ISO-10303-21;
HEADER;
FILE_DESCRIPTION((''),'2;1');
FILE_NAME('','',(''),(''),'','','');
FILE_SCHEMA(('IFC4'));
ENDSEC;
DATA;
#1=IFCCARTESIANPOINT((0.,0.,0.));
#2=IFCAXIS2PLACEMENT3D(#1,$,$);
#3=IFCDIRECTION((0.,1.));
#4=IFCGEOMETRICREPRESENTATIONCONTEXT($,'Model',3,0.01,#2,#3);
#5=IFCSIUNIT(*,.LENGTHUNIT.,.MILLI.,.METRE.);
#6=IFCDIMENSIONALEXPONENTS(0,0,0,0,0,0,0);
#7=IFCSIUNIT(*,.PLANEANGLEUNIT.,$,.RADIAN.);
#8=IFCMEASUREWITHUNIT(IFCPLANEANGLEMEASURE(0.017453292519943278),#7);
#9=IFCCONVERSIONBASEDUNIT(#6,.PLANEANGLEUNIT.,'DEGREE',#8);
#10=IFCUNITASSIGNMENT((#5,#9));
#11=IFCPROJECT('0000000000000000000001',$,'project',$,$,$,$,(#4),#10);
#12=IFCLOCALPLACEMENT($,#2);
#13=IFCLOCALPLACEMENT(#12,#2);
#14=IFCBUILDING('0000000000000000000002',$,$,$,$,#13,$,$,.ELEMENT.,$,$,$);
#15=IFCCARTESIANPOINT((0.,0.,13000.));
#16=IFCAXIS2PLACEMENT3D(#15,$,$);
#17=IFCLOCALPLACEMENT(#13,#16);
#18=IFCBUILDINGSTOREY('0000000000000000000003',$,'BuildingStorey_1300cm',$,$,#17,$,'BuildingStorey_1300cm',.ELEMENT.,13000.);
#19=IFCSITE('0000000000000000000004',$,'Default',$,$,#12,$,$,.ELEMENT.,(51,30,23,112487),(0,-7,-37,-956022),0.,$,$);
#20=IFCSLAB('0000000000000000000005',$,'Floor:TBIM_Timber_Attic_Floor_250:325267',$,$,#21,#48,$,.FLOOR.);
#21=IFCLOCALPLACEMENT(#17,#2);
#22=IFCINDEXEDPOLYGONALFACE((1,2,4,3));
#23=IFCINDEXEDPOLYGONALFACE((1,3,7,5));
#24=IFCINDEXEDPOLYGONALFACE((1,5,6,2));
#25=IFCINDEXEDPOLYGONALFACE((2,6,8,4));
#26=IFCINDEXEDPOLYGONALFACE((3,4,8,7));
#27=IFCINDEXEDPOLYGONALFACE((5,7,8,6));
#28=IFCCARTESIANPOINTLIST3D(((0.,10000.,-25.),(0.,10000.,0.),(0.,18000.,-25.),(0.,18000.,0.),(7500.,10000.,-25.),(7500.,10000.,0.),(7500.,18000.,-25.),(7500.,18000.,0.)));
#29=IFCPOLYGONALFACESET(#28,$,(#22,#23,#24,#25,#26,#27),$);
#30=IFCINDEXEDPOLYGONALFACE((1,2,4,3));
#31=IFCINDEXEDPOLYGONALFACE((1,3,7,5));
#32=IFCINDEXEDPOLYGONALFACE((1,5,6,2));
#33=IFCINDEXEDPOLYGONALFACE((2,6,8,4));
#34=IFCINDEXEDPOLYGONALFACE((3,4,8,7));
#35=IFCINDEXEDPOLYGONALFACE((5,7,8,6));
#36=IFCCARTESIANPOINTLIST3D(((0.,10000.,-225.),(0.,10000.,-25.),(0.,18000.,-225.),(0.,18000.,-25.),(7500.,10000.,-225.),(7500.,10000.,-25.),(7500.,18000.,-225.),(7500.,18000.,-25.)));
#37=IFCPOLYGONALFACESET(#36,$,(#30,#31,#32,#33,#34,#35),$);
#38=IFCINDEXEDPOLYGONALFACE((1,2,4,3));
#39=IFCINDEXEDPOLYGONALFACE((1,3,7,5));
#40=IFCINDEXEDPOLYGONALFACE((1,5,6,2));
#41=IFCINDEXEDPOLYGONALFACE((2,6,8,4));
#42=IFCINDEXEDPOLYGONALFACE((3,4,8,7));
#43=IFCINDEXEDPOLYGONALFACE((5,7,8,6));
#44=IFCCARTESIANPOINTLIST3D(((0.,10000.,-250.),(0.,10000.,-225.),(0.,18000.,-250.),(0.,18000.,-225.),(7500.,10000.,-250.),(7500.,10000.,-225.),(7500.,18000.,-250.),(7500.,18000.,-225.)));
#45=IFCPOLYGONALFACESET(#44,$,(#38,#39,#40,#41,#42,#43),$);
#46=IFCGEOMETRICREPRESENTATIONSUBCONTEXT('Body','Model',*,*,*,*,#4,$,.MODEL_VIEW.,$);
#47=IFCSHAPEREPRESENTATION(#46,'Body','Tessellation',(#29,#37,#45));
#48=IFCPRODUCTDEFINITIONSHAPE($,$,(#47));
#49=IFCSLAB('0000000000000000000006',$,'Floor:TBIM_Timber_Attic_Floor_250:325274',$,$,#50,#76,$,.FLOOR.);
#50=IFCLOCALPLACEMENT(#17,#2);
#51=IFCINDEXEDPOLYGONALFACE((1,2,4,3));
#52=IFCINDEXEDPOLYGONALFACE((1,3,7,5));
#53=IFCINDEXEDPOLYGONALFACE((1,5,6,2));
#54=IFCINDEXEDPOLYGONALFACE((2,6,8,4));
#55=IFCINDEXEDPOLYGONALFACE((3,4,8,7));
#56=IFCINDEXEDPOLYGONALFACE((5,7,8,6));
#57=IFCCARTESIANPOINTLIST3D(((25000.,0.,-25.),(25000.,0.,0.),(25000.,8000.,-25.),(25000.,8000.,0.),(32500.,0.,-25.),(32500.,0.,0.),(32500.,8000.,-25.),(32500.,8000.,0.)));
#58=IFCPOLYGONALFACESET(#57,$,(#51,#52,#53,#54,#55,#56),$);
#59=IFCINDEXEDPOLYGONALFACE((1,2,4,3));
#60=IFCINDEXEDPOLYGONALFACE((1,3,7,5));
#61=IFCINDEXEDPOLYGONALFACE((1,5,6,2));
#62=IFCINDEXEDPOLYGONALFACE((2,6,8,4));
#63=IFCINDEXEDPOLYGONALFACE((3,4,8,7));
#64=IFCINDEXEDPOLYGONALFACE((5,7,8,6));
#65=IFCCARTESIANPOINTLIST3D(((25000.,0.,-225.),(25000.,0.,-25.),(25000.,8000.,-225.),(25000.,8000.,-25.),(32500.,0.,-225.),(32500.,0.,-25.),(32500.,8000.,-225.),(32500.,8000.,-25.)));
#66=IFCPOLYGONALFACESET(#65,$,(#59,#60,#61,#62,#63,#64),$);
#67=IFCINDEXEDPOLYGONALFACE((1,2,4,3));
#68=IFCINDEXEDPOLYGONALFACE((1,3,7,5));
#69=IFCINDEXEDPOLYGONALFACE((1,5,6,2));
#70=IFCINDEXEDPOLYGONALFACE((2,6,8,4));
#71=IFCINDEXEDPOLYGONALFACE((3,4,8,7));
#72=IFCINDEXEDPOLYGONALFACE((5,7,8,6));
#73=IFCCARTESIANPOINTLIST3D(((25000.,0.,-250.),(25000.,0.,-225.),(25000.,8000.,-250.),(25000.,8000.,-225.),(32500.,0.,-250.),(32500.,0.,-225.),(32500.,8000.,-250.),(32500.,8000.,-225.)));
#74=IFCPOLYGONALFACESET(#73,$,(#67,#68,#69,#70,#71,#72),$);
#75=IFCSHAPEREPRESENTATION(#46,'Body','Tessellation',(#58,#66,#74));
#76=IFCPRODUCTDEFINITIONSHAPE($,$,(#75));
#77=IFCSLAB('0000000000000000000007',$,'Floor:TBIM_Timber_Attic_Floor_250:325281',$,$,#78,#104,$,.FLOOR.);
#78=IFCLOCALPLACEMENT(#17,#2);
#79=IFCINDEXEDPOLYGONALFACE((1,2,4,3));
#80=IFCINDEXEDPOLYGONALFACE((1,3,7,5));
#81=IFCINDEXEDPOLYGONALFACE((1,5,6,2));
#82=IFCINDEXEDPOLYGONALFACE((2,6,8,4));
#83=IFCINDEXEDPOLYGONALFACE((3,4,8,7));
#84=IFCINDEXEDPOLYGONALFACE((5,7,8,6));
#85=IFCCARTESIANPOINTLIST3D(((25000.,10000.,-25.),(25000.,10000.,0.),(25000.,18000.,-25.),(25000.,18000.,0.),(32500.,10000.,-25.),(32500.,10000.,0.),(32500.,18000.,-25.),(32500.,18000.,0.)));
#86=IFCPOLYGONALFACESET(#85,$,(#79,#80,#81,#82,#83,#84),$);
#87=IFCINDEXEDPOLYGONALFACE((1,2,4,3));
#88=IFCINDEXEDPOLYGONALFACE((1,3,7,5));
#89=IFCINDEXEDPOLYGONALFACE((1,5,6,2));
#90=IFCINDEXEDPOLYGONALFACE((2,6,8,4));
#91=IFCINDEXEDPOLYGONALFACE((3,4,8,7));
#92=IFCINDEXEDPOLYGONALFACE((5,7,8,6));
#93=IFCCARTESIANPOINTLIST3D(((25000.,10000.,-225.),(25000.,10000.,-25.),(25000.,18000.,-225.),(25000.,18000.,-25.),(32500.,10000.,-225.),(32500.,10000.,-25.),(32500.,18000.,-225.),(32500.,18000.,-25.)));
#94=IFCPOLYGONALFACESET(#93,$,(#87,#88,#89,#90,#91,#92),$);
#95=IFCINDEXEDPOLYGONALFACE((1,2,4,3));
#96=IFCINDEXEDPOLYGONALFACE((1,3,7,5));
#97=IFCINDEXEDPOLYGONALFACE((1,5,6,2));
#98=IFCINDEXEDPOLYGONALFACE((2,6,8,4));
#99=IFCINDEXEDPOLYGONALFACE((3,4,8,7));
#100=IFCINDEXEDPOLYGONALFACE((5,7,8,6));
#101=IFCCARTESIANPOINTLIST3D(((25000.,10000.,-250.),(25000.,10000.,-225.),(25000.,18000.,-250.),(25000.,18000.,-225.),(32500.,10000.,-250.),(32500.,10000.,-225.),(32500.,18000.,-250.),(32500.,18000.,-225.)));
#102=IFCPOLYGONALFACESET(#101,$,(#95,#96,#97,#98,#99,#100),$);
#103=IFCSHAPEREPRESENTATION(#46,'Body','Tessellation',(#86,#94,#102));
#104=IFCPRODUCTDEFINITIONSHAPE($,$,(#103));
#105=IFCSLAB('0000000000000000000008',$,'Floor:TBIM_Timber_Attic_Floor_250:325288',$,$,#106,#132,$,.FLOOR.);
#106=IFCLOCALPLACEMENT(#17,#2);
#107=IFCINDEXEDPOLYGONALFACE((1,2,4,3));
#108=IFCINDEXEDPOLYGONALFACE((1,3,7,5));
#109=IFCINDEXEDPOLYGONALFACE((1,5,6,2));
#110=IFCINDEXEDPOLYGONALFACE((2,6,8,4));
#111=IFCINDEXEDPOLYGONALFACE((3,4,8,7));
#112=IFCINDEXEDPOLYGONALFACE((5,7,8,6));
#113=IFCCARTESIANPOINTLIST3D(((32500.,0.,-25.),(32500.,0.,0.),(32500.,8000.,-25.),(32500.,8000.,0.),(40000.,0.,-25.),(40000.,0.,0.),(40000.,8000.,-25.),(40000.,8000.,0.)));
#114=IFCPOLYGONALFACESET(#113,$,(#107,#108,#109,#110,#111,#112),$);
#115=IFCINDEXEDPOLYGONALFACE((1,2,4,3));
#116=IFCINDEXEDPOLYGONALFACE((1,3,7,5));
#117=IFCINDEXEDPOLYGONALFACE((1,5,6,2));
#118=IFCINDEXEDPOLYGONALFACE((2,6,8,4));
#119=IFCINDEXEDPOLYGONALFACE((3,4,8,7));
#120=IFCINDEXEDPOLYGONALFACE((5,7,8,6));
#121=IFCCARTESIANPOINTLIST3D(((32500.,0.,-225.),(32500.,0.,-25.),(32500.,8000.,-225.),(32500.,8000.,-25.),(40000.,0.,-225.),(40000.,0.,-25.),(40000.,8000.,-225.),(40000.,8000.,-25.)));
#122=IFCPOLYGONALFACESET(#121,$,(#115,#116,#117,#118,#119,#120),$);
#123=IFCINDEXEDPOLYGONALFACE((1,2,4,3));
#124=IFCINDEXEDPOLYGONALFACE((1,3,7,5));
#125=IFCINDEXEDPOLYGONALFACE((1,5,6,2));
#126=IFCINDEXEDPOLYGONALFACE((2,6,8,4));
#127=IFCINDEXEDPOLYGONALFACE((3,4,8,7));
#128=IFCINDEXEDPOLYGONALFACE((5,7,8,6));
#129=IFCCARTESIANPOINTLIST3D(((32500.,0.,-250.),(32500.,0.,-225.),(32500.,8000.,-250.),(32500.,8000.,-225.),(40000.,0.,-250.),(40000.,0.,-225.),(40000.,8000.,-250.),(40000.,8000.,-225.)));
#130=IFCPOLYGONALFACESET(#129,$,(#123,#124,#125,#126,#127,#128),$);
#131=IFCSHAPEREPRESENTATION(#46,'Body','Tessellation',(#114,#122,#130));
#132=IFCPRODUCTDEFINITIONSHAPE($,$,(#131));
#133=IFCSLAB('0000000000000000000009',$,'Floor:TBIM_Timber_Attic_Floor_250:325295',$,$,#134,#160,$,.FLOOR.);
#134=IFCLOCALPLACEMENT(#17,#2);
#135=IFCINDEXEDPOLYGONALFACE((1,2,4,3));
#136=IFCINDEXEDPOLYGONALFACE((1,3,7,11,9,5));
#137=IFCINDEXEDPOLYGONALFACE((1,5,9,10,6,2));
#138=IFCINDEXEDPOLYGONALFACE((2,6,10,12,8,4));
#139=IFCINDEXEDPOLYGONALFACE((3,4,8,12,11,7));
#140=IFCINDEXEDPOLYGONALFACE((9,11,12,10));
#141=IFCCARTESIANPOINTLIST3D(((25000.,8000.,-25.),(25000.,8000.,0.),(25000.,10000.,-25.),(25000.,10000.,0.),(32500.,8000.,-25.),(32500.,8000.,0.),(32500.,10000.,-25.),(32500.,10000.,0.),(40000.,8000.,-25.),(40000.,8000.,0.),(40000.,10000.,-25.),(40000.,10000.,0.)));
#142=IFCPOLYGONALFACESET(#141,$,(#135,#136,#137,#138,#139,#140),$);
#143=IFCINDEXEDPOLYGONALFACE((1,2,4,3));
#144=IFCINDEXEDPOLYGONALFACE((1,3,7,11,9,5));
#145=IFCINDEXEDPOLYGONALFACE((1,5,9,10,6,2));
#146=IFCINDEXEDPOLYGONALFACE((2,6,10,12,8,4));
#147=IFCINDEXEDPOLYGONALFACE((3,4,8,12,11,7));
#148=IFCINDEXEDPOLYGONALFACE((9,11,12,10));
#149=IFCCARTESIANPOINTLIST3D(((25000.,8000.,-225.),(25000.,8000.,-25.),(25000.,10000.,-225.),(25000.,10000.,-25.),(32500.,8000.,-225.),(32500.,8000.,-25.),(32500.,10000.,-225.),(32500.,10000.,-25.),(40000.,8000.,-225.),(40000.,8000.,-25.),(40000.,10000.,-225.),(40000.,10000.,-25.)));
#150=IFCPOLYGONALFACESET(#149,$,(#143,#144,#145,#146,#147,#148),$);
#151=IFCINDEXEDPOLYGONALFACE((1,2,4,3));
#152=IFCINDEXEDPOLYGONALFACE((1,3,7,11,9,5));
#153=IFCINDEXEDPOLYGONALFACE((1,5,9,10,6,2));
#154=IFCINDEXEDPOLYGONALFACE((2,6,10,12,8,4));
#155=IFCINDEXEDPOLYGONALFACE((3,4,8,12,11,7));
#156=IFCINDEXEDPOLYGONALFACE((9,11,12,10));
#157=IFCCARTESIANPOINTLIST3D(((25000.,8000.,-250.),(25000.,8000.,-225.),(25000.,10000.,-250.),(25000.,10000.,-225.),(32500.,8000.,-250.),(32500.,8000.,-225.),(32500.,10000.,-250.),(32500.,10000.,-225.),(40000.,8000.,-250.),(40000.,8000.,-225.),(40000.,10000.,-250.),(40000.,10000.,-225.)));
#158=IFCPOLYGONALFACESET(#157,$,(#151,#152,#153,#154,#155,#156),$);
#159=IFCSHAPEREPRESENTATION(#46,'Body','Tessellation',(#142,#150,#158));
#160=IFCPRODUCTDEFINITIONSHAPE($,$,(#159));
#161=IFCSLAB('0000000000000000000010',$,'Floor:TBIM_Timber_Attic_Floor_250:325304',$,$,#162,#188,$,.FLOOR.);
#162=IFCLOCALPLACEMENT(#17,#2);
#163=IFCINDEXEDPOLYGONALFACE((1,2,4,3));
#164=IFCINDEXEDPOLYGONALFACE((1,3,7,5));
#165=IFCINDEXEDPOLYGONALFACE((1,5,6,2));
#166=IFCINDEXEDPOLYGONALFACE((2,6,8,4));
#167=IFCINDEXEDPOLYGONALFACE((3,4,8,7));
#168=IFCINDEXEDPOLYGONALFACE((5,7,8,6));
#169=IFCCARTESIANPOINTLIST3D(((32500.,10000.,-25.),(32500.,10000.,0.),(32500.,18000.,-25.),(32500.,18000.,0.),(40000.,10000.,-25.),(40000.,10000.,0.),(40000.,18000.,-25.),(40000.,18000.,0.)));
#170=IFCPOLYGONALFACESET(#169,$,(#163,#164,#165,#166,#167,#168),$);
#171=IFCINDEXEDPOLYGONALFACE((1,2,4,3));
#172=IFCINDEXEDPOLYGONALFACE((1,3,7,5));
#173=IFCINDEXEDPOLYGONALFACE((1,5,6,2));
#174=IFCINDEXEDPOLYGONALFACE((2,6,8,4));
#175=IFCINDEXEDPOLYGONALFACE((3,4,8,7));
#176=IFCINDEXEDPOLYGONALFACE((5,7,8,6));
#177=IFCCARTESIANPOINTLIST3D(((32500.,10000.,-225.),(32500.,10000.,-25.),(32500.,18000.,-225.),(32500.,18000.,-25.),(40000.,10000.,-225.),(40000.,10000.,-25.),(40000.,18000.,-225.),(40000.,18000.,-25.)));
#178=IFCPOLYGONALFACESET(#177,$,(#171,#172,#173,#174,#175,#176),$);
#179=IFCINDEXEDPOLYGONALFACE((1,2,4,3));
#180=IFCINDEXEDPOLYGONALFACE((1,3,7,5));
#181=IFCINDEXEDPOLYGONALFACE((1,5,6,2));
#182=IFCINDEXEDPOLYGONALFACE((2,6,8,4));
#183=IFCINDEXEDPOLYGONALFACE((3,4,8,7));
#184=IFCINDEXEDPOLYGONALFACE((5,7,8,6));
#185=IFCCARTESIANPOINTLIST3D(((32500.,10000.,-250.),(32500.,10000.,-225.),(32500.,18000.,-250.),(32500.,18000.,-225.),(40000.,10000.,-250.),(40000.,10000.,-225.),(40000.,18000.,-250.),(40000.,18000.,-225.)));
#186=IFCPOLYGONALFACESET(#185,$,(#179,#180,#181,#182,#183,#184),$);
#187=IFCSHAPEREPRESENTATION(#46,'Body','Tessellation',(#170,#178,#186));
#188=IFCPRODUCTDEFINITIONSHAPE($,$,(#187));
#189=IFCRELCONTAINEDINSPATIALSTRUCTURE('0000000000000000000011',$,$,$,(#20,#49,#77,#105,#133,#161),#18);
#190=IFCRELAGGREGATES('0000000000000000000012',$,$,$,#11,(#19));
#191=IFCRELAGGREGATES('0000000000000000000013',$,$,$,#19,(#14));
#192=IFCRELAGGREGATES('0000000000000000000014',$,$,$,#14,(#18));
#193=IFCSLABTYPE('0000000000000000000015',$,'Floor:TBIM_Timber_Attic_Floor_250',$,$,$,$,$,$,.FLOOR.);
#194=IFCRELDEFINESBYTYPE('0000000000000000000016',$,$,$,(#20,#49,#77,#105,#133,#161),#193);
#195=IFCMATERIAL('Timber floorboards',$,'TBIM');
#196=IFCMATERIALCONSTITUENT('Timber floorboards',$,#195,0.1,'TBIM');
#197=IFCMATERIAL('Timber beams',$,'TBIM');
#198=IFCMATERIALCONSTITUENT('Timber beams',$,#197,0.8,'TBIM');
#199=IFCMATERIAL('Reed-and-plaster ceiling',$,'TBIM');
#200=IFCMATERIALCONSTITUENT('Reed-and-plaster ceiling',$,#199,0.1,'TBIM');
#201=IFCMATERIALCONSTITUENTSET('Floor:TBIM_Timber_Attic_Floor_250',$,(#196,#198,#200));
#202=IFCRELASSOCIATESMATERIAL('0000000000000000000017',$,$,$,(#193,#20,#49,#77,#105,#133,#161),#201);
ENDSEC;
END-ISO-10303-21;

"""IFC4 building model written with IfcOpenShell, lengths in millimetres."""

from ifc_helpers import new_model, entity, si_unit, converted_unit, direction, frame, origin, place, context, subcontext, project, spatial, indexed_curve, outline, extrude, material, constituent, constituent_set, type_object, element, save


model = new_model("IFC4")

# Units and contexts
model_context = context("Model", 3, precision=0.01, world=origin(), true_north=direction((0.0, 1.0)))
body_context = subcontext(model_context, "Body", "Model", "MODEL_VIEW")
ifc_project = project(units=[si_unit("LENGTHUNIT", "METRE", prefix="MILLI"), converted_unit("PLANEANGLEUNIT", "DEGREE", entity("IfcPlaneAngleMeasure", 0.017453292519943278), si_unit("PLANEANGLEUNIT", "RADIAN"), dimensions=[0, 0, 0, 0, 0, 0, 0])], contexts=[model_context])

# Site, building, storey
site_placement = place(None, origin())
site = spatial("IfcSite", under=ifc_project, at=site_placement, Name="Default", CompositionType="ELEMENT", RefLatitude=(51, 30, 23, 112487), RefLongitude=(0, -7, -37, -956022), RefElevation=0.0)
building_placement = place(site_placement, origin())
building = spatial("IfcBuilding", under=site, at=building_placement, CompositionType="ELEMENT")
storey_placement = place(building_placement, frame((0.0, 0.0, 13000.0)))
storey = spatial("IfcBuildingStorey", under=building, at=storey_placement, Name="BuildingStorey_1300cm", LongName="BuildingStorey_1300cm", CompositionType="ELEMENT", Elevation=13000.0)

# Slabs
ifc_material_1 = material(Name="Timber floorboards", Category="TBIM")
ifc_constituent_1 = constituent(ifc_material_1, Name="Timber floorboards", Category="TBIM", fraction=0.1)
ifc_material_2 = material(Name="Timber beams", Category="TBIM")
ifc_constituent_2 = constituent(ifc_material_2, Name="Timber beams", Category="TBIM", fraction=0.8)
ifc_material_3 = material(Name="Reed-and-plaster ceiling", Category="TBIM")
ifc_constituent_3 = constituent(ifc_material_3, Name="Reed-and-plaster ceiling", Category="TBIM", fraction=0.1)
ifc_constituent_set_1 = constituent_set(constituents=[ifc_constituent_1, ifc_constituent_2, ifc_constituent_3], Name="Floor:TBIM_Timber_Attic_Floor_250")
slab_type_1 = type_object("IfcSlabType", Name="Floor:TBIM_Timber_Attic_Floor_250", PredefinedType="FLOOR", material=ifc_constituent_set_1)
slab_1_placement = place(storey_placement, origin())
element("IfcSlab", 1, at=slab_1_placement, inside=storey, type_object=slab_type_1, material=ifc_constituent_set_1, Name="Floor:TBIM_Timber_Attic_Floor_250:325267", PredefinedType="FLOOR", context=body_context, shape_type="SweptSolid", body=[
    extrude(outline(indexed_curve([(-3750.0, -4000.0), (3750.0, -4000.0), (3750.0, 4000.0), (-3750.0, 4000.0), (-3750.0, -4000.0)], self_intersect=False)), frame((3750.0, 14000.0, -25.0), z_axis=(0.0, 0.0, 1.0), x_axis=(-1.0, 0.0, 0.0)), (0.0, 0.0, 1.0), 25.0),
    extrude(outline(indexed_curve([(-3750.0, -4000.0), (3750.0, -4000.0), (3750.0, 4000.0), (-3750.0, 4000.0), (-3750.0, -4000.0)], self_intersect=False)), frame((3750.0, 14000.0, -225.0), z_axis=(0.0, 0.0, 1.0), x_axis=(-1.0, 0.0, 0.0)), (0.0, 0.0, 1.0), 200.0),
    extrude(outline(indexed_curve([(-3750.0, -4000.0), (3750.0, -4000.0), (3750.0, 4000.0), (-3750.0, 4000.0), (-3750.0, -4000.0)], self_intersect=False)), frame((3750.0, 14000.0, -250.0), z_axis=(0.0, 0.0, 1.0), x_axis=(-1.0, 0.0, 0.0)), (0.0, 0.0, 1.0), 25.0),
])
slab_2_placement = place(storey_placement, origin())
element("IfcSlab", 2, at=slab_2_placement, inside=storey, type_object=slab_type_1, material=ifc_constituent_set_1, Name="Floor:TBIM_Timber_Attic_Floor_250:325274", PredefinedType="FLOOR", context=body_context, shape_type="SweptSolid", body=[
    extrude(outline(indexed_curve([(-3750.0, -4000.0), (3750.0, -4000.0), (3750.0, 4000.0), (-3750.0, 4000.0), (-3750.0, -4000.0)], self_intersect=False)), frame((28750.0, 4000.0, -25.0), z_axis=(0.0, 0.0, 1.0), x_axis=(-1.0, 0.0, 0.0)), (0.0, 0.0, 1.0), 25.0),
    extrude(outline(indexed_curve([(-3750.0, -4000.0), (3750.0, -4000.0), (3750.0, 4000.0), (-3750.0, 4000.0), (-3750.0, -4000.0)], self_intersect=False)), frame((28750.0, 4000.0, -225.0), z_axis=(0.0, 0.0, 1.0), x_axis=(-1.0, 0.0, 0.0)), (0.0, 0.0, 1.0), 200.0),
    extrude(outline(indexed_curve([(-3750.0, -4000.0), (3750.0, -4000.0), (3750.0, 4000.0), (-3750.0, 4000.0), (-3750.0, -4000.0)], self_intersect=False)), frame((28750.0, 4000.0, -250.0), z_axis=(0.0, 0.0, 1.0), x_axis=(-1.0, 0.0, 0.0)), (0.0, 0.0, 1.0), 25.0),
])
slab_3_placement = place(storey_placement, origin())
element("IfcSlab", 3, at=slab_3_placement, inside=storey, type_object=slab_type_1, material=ifc_constituent_set_1, Name="Floor:TBIM_Timber_Attic_Floor_250:325281", PredefinedType="FLOOR", context=body_context, shape_type="SweptSolid", body=[
    extrude(outline(indexed_curve([(-3750.0, -4000.0), (3750.0, -4000.0), (3750.0, 4000.0), (-3750.0, 4000.0), (-3750.0, -4000.0)], self_intersect=False)), frame((28750.0, 14000.0, -25.0), z_axis=(0.0, 0.0, 1.0), x_axis=(-1.0, 0.0, 0.0)), (0.0, 0.0, 1.0), 25.0),
    extrude(outline(indexed_curve([(-3750.0, -4000.0), (3750.0, -4000.0), (3750.0, 4000.0), (-3750.0, 4000.0), (-3750.0, -4000.0)], self_intersect=False)), frame((28750.0, 14000.0, -225.0), z_axis=(0.0, 0.0, 1.0), x_axis=(-1.0, 0.0, 0.0)), (0.0, 0.0, 1.0), 200.0),
    extrude(outline(indexed_curve([(-3750.0, -4000.0), (3750.0, -4000.0), (3750.0, 4000.0), (-3750.0, 4000.0), (-3750.0, -4000.0)], self_intersect=False)), frame((28750.0, 14000.0, -250.0), z_axis=(0.0, 0.0, 1.0), x_axis=(-1.0, 0.0, 0.0)), (0.0, 0.0, 1.0), 25.0),
])
slab_4_placement = place(storey_placement, origin())
element("IfcSlab", 4, at=slab_4_placement, inside=storey, type_object=slab_type_1, material=ifc_constituent_set_1, Name="Floor:TBIM_Timber_Attic_Floor_250:325288", PredefinedType="FLOOR", context=body_context, shape_type="SweptSolid", body=[
    extrude(outline(indexed_curve([(-3750.0, -4000.0), (3750.0, -4000.0), (3750.0, 4000.0), (-3750.0, 4000.0), (-3750.0, -4000.0)], self_intersect=False)), frame((36250.0, 4000.0, -25.0), z_axis=(0.0, 0.0, 1.0), x_axis=(-1.0, 0.0, 0.0)), (0.0, 0.0, 1.0), 25.0),
    extrude(outline(indexed_curve([(-3750.0, -4000.0), (3750.0, -4000.0), (3750.0, 4000.0), (-3750.0, 4000.0), (-3750.0, -4000.0)], self_intersect=False)), frame((36250.0, 4000.0, -225.0), z_axis=(0.0, 0.0, 1.0), x_axis=(-1.0, 0.0, 0.0)), (0.0, 0.0, 1.0), 200.0),
    extrude(outline(indexed_curve([(-3750.0, -4000.0), (3750.0, -4000.0), (3750.0, 4000.0), (-3750.0, 4000.0), (-3750.0, -4000.0)], self_intersect=False)), frame((36250.0, 4000.0, -250.0), z_axis=(0.0, 0.0, 1.0), x_axis=(-1.0, 0.0, 0.0)), (0.0, 0.0, 1.0), 25.0),
])
slab_5_placement = place(storey_placement, origin())
element("IfcSlab", 5, at=slab_5_placement, inside=storey, type_object=slab_type_1, material=ifc_constituent_set_1, Name="Floor:TBIM_Timber_Attic_Floor_250:325295", PredefinedType="FLOOR", context=body_context, shape_type="SweptSolid", body=[
    extrude(outline(indexed_curve([(-7500.0, -1000.0), (0.0, -1000.0), (7500.0, -1000.0), (7500.0, 1000.0), (0.0, 1000.0), (-7500.0, 1000.0), (-7500.0, -1000.0)], self_intersect=False)), frame((32500.0, 9000.0, -25.0), z_axis=(0.0, 0.0, 1.0), x_axis=(-1.0, 0.0, 0.0)), (0.0, 0.0, 1.0), 25.0),
    extrude(outline(indexed_curve([(-7500.0, -1000.0), (0.0, -1000.0), (7500.0, -1000.0), (7500.0, 1000.0), (0.0, 1000.0), (-7500.0, 1000.0), (-7500.0, -1000.0)], self_intersect=False)), frame((32500.0, 9000.0, -225.0), z_axis=(0.0, 0.0, 1.0), x_axis=(-1.0, 0.0, 0.0)), (0.0, 0.0, 1.0), 200.0),
    extrude(outline(indexed_curve([(-7500.0, -1000.0), (0.0, -1000.0), (7500.0, -1000.0), (7500.0, 1000.0), (0.0, 1000.0), (-7500.0, 1000.0), (-7500.0, -1000.0)], self_intersect=False)), frame((32500.0, 9000.0, -250.0), z_axis=(0.0, 0.0, 1.0), x_axis=(-1.0, 0.0, 0.0)), (0.0, 0.0, 1.0), 25.0),
])
slab_6_placement = place(storey_placement, origin())
element("IfcSlab", 6, at=slab_6_placement, inside=storey, type_object=slab_type_1, material=ifc_constituent_set_1, Name="Floor:TBIM_Timber_Attic_Floor_250:325304", PredefinedType="FLOOR", context=body_context, shape_type="SweptSolid", body=[
    extrude(outline(indexed_curve([(-3750.0, -4000.0), (3750.0, -4000.0), (3750.0, 4000.0), (-3750.0, 4000.0), (-3750.0, -4000.0)], self_intersect=False)), frame((36250.0, 14000.0, -25.0), z_axis=(0.0, 0.0, 1.0), x_axis=(-1.0, 0.0, 0.0)), (0.0, 0.0, 1.0), 25.0),
    extrude(outline(indexed_curve([(-3750.0, -4000.0), (3750.0, -4000.0), (3750.0, 4000.0), (-3750.0, 4000.0), (-3750.0, -4000.0)], self_intersect=False)), frame((36250.0, 14000.0, -225.0), z_axis=(0.0, 0.0, 1.0), x_axis=(-1.0, 0.0, 0.0)), (0.0, 0.0, 1.0), 200.0),
    extrude(outline(indexed_curve([(-3750.0, -4000.0), (3750.0, -4000.0), (3750.0, 4000.0), (-3750.0, 4000.0), (-3750.0, -4000.0)], self_intersect=False)), frame((36250.0, 14000.0, -250.0), z_axis=(0.0, 0.0, 1.0), x_axis=(-1.0, 0.0, 0.0)), (0.0, 0.0, 1.0), 25.0),
])

save(model, "model.ifc")
